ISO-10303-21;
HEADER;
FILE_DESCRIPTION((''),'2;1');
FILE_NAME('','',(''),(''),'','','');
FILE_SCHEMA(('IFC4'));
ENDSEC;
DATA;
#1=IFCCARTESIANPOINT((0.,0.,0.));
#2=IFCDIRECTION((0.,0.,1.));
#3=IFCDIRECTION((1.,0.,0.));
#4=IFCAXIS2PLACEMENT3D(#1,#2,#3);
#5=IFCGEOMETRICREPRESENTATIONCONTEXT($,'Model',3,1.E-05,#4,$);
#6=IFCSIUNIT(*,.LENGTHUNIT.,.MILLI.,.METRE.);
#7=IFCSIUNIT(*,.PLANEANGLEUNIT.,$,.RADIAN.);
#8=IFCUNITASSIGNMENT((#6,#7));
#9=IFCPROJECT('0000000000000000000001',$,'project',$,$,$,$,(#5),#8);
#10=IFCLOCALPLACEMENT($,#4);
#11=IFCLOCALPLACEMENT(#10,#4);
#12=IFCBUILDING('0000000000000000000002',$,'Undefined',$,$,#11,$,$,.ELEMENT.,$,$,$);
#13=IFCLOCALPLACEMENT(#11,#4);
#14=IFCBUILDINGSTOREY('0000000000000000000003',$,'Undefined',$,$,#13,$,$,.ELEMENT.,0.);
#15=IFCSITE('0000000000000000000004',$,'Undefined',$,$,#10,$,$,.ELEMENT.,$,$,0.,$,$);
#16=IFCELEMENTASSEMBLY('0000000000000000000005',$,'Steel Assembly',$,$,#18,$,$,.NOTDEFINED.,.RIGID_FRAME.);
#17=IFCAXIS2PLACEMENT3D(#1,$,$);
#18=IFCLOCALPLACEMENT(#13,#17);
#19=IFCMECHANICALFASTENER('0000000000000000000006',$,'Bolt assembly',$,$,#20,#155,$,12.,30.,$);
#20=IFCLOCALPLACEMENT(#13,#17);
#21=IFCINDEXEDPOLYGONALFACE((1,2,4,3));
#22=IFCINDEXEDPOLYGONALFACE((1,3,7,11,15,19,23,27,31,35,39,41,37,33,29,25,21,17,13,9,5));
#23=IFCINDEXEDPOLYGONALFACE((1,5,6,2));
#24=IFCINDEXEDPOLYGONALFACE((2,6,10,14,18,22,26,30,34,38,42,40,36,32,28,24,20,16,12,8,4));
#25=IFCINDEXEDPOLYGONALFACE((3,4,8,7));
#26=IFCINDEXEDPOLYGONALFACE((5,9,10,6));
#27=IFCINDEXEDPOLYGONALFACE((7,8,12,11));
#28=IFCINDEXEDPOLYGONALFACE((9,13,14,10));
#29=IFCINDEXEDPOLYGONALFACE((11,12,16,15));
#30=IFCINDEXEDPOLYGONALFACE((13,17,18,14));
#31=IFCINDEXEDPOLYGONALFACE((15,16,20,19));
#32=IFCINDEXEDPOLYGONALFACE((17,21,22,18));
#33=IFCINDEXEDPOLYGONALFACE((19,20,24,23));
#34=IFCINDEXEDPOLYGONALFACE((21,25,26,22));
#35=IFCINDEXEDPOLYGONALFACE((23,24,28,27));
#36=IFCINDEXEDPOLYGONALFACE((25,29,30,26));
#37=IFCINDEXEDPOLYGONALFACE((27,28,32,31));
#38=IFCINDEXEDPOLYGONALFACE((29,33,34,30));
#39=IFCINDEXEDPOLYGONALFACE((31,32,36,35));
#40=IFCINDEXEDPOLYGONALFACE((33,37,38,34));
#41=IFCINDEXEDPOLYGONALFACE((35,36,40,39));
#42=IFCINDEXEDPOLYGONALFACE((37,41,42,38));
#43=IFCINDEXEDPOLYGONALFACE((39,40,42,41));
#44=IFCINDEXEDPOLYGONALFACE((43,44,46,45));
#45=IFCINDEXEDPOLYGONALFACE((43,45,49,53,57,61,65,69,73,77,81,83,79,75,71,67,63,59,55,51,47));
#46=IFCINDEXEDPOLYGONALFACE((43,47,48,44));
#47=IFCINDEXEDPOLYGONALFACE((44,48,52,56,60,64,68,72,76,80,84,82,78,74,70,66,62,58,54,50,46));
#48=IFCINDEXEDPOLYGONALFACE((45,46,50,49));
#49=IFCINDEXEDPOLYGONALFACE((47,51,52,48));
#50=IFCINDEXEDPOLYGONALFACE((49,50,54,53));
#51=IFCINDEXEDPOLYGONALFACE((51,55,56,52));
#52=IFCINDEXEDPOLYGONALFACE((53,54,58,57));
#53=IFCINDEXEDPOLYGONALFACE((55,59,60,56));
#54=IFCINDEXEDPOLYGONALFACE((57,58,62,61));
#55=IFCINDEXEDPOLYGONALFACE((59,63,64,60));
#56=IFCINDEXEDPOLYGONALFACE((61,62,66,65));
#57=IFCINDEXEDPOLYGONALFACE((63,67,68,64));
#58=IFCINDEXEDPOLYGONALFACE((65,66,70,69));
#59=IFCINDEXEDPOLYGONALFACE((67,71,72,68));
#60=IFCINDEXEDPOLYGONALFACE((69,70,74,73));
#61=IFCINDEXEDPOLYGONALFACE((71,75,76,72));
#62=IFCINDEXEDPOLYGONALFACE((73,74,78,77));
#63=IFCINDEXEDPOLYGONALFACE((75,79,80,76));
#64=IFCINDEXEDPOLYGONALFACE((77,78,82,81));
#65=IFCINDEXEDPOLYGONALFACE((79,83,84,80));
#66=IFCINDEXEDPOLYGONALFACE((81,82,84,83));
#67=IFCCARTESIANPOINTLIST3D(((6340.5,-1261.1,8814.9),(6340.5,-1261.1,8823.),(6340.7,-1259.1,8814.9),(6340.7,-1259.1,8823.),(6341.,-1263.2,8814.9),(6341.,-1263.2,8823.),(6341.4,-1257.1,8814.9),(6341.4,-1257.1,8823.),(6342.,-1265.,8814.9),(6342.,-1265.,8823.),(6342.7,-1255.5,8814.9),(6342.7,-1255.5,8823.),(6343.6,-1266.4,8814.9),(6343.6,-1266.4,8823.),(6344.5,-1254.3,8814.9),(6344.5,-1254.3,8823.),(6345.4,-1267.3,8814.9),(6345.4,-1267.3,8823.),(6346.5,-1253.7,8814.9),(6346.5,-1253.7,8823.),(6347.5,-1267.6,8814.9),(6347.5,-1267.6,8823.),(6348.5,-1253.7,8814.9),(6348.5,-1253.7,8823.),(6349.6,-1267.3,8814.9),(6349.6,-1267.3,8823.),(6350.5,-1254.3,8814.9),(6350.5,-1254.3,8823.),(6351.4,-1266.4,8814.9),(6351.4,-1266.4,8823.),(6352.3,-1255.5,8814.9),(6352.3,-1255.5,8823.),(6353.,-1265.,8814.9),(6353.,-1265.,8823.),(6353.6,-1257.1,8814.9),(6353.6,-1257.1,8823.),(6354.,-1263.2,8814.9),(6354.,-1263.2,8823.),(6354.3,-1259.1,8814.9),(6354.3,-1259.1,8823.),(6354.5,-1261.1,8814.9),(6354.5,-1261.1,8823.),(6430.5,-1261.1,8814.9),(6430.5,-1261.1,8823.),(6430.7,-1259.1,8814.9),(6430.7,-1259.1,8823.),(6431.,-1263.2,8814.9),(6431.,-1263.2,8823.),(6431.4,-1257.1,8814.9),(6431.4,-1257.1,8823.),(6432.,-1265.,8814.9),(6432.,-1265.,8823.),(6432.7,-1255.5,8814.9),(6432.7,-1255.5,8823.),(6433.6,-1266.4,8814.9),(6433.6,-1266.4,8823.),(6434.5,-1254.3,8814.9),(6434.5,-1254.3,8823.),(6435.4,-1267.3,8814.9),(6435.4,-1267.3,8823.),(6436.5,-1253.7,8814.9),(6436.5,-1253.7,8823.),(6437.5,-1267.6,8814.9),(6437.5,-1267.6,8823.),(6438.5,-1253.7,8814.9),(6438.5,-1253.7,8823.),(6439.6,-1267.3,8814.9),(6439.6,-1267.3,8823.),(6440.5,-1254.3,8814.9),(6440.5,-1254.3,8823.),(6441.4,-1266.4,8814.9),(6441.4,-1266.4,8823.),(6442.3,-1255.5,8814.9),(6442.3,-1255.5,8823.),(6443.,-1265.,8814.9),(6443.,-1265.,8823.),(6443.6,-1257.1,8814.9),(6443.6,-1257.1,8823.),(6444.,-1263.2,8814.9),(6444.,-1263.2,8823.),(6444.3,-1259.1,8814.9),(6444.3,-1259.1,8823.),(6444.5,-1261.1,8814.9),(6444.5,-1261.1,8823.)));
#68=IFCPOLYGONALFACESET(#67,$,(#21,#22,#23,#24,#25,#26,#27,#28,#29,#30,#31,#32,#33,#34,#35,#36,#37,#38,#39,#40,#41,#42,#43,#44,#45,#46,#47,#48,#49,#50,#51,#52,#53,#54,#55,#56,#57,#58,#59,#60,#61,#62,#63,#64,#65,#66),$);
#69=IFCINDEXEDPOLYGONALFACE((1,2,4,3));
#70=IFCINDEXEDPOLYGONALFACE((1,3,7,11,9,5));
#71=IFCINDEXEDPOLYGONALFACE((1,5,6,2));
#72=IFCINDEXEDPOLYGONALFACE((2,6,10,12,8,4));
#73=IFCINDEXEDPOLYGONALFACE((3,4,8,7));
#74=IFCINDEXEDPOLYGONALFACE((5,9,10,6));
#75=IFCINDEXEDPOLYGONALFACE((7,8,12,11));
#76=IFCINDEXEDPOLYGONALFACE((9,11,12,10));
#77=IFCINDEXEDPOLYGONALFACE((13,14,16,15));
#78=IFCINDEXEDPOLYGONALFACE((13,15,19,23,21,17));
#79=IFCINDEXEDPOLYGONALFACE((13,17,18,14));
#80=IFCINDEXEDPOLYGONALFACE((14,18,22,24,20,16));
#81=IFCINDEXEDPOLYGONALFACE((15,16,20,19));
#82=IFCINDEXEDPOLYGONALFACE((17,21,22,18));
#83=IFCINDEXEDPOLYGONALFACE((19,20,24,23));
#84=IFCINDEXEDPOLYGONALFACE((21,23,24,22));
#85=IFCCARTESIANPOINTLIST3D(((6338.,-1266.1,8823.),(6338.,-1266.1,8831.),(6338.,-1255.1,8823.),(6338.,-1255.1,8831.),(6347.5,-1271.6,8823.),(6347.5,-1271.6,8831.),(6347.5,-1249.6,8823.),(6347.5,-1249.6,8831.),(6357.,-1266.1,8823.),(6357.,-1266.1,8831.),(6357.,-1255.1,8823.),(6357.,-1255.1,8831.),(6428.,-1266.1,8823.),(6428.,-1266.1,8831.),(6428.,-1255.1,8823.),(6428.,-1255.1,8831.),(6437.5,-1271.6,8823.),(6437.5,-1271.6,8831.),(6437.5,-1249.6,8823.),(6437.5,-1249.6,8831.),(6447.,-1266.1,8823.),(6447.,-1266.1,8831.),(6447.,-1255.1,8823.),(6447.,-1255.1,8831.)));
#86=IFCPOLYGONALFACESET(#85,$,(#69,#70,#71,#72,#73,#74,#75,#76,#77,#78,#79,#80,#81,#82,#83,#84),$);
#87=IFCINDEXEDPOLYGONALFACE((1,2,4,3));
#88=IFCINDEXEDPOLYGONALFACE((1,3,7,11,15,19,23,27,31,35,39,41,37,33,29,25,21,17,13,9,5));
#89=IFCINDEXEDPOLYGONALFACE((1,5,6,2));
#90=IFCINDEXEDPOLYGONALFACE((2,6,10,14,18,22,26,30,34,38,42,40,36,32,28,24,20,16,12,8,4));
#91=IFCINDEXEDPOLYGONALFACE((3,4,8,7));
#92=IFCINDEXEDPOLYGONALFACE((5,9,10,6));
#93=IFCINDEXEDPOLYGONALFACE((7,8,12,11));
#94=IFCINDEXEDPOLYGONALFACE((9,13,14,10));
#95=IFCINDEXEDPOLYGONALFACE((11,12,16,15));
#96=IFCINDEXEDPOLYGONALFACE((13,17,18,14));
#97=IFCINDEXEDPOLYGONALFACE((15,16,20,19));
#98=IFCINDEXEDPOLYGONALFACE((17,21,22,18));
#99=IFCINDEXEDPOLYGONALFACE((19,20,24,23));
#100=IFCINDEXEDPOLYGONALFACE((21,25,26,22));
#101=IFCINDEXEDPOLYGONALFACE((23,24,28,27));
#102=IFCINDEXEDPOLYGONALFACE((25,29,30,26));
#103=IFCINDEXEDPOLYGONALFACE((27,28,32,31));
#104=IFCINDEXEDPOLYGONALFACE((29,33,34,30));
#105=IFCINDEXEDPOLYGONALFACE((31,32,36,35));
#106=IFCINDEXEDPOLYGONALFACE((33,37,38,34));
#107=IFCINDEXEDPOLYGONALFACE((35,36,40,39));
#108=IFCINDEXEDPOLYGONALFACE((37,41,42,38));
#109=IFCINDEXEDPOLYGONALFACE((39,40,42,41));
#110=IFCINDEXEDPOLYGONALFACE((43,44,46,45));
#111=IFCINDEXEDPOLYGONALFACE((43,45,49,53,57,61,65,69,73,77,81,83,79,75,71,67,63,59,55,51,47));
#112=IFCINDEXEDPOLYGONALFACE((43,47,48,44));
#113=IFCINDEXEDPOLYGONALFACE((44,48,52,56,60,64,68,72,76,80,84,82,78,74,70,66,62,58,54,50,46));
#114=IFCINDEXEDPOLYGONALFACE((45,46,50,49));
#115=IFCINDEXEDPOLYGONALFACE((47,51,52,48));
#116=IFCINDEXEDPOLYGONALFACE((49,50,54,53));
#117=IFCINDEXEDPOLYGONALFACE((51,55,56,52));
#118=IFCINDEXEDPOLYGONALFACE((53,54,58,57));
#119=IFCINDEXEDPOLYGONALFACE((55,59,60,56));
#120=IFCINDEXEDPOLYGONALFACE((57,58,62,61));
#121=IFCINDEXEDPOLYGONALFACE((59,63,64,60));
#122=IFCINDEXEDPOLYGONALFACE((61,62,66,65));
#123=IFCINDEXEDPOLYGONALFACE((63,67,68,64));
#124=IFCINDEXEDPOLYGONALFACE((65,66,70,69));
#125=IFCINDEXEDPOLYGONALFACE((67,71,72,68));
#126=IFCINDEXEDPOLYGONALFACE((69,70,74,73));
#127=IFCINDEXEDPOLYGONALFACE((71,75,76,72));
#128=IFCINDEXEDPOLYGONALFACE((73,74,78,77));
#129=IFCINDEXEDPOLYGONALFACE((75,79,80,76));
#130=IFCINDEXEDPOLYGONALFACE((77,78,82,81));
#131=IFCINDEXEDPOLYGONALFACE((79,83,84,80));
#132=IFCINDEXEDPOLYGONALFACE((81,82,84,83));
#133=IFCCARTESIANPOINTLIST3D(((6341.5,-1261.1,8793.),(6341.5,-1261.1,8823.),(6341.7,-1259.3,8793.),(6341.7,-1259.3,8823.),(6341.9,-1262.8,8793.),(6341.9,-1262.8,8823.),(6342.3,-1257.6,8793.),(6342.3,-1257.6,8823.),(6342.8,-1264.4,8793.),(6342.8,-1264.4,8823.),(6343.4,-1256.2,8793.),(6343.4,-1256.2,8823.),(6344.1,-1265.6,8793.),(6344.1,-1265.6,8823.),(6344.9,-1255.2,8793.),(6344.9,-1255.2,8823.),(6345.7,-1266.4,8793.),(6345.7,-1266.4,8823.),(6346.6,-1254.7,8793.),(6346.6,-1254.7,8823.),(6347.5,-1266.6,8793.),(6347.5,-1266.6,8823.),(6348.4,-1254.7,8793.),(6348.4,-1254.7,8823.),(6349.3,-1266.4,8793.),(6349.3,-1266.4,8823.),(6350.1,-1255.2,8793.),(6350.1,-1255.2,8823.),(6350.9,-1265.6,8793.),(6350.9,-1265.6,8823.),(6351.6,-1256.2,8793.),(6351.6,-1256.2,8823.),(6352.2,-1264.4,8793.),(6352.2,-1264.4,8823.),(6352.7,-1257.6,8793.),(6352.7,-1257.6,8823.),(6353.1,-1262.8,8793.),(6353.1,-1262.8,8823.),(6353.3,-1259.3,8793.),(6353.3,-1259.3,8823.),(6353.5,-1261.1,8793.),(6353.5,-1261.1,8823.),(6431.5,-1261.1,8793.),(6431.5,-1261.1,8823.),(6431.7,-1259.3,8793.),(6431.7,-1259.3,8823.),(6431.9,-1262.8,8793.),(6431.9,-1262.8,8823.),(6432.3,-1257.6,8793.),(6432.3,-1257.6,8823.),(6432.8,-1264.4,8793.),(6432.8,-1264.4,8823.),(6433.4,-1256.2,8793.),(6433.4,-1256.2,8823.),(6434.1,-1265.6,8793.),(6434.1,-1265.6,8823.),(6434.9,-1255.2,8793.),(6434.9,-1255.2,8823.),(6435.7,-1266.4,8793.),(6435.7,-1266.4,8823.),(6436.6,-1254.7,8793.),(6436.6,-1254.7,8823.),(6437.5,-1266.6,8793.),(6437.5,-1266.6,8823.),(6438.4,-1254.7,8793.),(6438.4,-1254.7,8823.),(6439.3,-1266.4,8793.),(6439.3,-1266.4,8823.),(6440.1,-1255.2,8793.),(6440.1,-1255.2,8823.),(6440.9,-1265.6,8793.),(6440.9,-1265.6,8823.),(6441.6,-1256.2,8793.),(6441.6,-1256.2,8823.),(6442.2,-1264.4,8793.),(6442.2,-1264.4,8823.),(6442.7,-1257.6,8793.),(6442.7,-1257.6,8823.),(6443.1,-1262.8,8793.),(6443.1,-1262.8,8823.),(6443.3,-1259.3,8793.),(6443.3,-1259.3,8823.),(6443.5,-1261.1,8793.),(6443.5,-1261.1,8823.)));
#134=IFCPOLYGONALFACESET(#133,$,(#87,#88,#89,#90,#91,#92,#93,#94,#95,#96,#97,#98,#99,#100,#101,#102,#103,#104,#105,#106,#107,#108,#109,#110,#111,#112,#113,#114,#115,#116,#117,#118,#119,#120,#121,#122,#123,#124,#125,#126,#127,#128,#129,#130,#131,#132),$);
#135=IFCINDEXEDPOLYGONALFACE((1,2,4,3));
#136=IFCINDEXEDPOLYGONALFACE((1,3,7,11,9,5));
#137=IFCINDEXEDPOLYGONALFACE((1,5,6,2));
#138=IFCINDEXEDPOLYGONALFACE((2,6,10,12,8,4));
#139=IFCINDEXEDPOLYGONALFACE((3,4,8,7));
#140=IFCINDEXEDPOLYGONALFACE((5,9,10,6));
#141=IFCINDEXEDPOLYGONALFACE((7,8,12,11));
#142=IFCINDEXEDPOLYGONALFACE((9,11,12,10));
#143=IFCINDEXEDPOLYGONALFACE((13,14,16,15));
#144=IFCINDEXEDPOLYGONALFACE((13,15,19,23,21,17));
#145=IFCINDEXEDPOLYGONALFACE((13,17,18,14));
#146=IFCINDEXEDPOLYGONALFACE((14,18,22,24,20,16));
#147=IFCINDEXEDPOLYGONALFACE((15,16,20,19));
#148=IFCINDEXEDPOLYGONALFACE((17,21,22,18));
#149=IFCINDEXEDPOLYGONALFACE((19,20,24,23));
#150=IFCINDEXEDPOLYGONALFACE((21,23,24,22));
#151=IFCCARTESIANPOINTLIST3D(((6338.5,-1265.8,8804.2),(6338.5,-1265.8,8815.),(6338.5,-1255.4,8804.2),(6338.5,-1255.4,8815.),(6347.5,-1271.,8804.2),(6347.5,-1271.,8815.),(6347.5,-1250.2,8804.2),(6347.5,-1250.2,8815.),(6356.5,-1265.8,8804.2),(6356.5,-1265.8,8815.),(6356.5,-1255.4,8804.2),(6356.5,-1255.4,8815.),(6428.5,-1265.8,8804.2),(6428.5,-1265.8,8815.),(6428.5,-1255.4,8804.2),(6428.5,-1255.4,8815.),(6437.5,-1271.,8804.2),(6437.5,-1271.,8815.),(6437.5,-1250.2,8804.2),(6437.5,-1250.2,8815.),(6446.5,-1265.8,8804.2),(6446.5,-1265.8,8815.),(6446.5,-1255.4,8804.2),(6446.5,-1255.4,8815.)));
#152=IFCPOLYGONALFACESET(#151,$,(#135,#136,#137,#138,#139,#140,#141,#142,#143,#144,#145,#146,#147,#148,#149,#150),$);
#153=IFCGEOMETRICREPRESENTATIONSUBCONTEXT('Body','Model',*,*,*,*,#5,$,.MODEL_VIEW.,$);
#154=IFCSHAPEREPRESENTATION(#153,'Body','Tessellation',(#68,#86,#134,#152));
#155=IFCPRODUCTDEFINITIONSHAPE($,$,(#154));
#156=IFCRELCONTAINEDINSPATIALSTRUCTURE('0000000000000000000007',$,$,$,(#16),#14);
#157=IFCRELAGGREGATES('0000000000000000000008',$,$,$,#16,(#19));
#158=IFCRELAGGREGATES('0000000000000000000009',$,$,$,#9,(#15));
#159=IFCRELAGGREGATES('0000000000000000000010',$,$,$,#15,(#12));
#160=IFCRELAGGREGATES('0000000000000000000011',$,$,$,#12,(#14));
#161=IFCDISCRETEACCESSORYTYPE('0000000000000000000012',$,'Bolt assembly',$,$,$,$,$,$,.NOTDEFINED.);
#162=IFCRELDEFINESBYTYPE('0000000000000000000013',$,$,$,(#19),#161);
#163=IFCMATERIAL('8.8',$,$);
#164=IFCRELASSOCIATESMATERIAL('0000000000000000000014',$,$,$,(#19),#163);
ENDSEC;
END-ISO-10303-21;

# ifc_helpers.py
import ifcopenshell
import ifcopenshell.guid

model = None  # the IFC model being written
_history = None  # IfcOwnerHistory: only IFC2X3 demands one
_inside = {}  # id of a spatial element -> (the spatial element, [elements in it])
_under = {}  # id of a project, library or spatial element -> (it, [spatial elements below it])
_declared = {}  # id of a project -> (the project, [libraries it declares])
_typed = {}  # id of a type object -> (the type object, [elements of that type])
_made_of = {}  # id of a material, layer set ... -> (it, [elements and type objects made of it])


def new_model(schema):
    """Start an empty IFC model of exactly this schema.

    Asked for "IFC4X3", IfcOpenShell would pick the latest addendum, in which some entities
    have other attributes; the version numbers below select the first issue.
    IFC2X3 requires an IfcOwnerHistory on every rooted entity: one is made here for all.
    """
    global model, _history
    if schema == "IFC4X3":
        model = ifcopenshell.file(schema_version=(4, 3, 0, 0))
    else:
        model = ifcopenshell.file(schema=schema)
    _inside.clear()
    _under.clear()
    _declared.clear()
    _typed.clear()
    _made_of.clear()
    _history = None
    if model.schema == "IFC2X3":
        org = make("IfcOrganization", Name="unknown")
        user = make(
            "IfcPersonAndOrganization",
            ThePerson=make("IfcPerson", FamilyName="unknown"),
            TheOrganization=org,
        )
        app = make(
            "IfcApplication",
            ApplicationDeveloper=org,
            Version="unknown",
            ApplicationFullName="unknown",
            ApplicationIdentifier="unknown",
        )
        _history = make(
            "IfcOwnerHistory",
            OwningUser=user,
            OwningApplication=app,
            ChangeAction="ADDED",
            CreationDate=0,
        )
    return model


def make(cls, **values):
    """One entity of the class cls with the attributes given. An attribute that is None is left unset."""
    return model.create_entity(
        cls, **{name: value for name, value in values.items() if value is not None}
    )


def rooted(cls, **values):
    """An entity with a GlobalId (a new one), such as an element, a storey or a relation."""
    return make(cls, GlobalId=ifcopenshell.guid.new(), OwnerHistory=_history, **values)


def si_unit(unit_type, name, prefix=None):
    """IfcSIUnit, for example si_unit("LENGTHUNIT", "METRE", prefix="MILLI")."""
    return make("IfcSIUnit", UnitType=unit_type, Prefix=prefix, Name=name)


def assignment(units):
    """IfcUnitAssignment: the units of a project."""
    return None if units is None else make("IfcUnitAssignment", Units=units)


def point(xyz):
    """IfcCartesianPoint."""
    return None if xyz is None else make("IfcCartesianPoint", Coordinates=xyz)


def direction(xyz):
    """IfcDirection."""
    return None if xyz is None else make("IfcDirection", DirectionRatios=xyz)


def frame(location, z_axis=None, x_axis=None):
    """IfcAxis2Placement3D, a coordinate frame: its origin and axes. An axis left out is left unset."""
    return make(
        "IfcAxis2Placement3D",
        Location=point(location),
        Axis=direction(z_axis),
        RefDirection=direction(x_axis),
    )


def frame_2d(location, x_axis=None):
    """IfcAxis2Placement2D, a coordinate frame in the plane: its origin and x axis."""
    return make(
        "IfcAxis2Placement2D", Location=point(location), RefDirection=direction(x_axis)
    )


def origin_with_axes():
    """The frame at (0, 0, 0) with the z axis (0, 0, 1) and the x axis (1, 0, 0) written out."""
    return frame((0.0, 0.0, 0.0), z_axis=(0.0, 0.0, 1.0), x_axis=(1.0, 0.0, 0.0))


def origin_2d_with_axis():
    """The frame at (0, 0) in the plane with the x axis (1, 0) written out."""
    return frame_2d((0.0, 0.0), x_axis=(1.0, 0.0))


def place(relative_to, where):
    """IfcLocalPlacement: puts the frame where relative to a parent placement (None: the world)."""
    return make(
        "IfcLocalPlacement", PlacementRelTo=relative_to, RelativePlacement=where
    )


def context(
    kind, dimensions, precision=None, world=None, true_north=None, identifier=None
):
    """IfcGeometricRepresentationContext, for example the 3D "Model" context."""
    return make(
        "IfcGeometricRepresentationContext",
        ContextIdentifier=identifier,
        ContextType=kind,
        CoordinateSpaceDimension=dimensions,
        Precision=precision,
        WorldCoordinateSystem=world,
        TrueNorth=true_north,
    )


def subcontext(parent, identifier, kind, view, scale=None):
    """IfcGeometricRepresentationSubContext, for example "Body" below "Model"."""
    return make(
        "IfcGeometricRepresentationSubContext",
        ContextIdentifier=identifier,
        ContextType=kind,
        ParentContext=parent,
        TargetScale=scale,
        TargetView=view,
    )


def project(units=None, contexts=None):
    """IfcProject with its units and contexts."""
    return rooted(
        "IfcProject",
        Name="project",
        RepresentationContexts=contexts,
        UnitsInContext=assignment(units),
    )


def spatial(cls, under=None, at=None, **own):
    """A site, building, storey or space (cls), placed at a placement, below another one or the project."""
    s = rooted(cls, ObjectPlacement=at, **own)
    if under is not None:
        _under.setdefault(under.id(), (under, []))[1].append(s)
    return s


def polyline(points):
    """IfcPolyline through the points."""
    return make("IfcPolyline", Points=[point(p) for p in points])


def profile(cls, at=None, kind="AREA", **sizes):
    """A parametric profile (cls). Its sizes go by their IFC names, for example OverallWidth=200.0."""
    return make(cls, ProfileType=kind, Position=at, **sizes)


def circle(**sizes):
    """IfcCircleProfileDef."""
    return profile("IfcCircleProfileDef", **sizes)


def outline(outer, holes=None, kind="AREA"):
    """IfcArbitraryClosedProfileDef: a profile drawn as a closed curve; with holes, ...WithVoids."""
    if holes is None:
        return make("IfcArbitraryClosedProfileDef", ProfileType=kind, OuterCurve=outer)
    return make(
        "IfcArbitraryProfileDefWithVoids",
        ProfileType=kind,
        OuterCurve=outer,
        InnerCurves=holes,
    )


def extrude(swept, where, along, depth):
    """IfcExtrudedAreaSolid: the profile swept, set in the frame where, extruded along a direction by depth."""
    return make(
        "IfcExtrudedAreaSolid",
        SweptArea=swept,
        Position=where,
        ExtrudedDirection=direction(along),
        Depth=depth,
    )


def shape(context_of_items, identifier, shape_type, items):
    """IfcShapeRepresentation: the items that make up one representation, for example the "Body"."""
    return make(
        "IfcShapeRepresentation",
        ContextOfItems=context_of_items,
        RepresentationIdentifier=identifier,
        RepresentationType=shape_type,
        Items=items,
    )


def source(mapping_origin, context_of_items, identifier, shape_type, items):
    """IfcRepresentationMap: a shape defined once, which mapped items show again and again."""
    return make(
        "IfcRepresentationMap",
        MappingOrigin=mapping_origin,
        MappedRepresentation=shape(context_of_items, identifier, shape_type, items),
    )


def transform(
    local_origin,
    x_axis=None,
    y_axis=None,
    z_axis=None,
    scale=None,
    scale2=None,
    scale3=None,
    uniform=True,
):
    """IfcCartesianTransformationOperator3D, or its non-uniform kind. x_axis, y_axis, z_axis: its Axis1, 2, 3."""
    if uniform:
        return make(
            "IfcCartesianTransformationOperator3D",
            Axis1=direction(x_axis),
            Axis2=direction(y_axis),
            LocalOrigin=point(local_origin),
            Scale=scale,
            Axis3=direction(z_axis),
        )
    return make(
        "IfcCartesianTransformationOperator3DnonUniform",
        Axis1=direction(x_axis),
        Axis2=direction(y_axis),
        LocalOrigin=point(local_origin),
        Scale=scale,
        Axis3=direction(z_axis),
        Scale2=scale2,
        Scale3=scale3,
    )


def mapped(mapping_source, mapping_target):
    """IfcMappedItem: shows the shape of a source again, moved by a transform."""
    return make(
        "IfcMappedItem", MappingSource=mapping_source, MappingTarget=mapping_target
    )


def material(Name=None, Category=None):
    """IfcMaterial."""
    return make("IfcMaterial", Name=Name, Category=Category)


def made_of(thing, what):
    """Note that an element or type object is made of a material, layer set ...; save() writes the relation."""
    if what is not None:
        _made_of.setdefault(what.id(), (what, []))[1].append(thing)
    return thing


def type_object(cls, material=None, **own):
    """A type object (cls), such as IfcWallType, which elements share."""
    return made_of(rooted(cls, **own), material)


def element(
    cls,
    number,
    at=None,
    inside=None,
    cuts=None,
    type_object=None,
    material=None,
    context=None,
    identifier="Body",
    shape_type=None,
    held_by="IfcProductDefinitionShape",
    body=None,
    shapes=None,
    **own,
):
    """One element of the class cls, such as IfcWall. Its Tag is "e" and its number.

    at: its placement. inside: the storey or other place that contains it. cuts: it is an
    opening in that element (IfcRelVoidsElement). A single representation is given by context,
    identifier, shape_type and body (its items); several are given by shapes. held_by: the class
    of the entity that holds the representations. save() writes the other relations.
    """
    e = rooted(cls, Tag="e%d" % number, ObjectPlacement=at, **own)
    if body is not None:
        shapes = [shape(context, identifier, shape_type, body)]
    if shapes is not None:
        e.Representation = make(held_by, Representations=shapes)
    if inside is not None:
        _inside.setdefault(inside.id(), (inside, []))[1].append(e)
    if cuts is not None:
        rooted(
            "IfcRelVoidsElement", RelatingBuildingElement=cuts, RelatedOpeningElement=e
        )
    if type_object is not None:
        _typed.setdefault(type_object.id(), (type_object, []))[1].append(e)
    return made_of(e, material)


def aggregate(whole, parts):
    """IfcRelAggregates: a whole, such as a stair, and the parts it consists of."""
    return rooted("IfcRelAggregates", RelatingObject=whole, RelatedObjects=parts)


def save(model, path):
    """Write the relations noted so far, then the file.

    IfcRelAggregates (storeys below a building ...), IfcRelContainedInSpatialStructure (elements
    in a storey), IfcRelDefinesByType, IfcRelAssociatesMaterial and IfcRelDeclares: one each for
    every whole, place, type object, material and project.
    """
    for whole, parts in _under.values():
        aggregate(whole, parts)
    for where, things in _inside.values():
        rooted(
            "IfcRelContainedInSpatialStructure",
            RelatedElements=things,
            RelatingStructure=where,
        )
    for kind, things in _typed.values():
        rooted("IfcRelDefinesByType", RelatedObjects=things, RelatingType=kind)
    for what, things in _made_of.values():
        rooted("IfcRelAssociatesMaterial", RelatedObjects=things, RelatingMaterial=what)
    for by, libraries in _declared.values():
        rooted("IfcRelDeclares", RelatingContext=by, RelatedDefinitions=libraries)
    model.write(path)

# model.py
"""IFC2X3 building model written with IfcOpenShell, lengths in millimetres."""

from ifc_helpers import new_model, si_unit, frame, origin_with_axes, origin_2d_with_axis, place, context, subcontext, project, spatial, polyline, circle, outline, extrude, source, transform, mapped, material, type_object, element, aggregate, save


model = new_model("IFC2X3")

# Units and contexts
model_context = context("Model", 3, precision=1e-05, world=origin_with_axes())
body_context = subcontext(model_context, "Body", "Model", "MODEL_VIEW")
ifc_project = project(units=[si_unit("LENGTHUNIT", "METRE", prefix="MILLI"), si_unit("PLANEANGLEUNIT", "RADIAN")], contexts=[model_context])

# Site, building, storey
site_placement = place(None, origin_with_axes())
site = spatial("IfcSite", under=ifc_project, at=site_placement, Name="Undefined", CompositionType="ELEMENT", RefElevation=0.0)
building_placement = place(site_placement, origin_with_axes())
building = spatial("IfcBuilding", under=site, at=building_placement, Name="Undefined", CompositionType="ELEMENT")
storey_placement = place(building_placement, origin_with_axes())
storey = spatial("IfcBuildingStorey", under=building, at=storey_placement, Name="Undefined", CompositionType="ELEMENT", Elevation=0.0)

# Element assembly
assembly_1_placement = place(storey_placement, origin_with_axes())
assembly_1 = element("IfcElementAssembly", 1, at=assembly_1_placement, inside=storey, Name="Steel Assembly", AssemblyPlace="NOTDEFINED", PredefinedType="RIGID_FRAME")

# Mechanical fastener
ifc_material_1 = material(Name="8.8")
discrete_accessory_type_1 = type_object("IfcDiscreteAccessoryType", Name="Bolt assembly")
shared_shape_1 = source(origin_with_axes(), body_context, "Body", "SweptSolid", [
    extrude(circle(Radius=7.0, at=origin_2d_with_axis()), frame((0.0, 0.0, 0.0), z_axis=(0.0, 1.0, 0.0), x_axis=(1.0, 0.0, 0.0)), (0.0, 0.0, 1.0), 8.1),
    extrude(outline(polyline([(11.0, 0.0), (5.5, 9.5), (-5.5, 9.5), (-11.0, 0.0), (-5.5, -9.5), (5.5, -9.5), (11.0, 0.0)])), frame((0.0, -8.0, 0.0), z_axis=(0.0, 1.0, 0.0), x_axis=(1.0, 0.0, 0.0)), (0.0, 0.0, 1.0), 8.0),
    extrude(circle(Radius=6.0, at=origin_2d_with_axis()), frame((0.0, 0.0, 0.0), z_axis=(0.0, 1.0, 0.0), x_axis=(1.0, 0.0, 0.0)), (0.0, 0.0, 1.0), 30.0),
    extrude(outline(polyline([(10.4, 0.0), (5.2, 9.0), (-5.2, 9.0), (-10.4, 0.0), (-5.2, -9.0), (5.2, -9.0), (10.4, 0.0)])), frame((0.0, 8.0, 0.0), z_axis=(0.0, 1.0, 0.0), x_axis=(1.0, 0.0, 0.0)), (0.0, 0.0, 1.0), 10.8),
])
mechanical_fastener_1_placement = place(assembly_1_placement, frame((6392.5, -1240.6, 8823.0), z_axis=(1.0, 0.0, 0.0), x_axis=(0.0, -1.0, 0.0)))
mechanical_fastener_1 = element("IfcMechanicalFastener", 2, at=mechanical_fastener_1_placement, type_object=discrete_accessory_type_1, material=ifc_material_1, Name="Bolt assembly", NominalDiameter=12.0, NominalLength=30.0, context=body_context, shape_type="MappedRepresentation", body=[
    mapped(shared_shape_1, transform((20.0, 0.0, -45.0))),
    mapped(shared_shape_1, transform((20.0, 0.0, 45.0))),
])

aggregate(assembly_1, [mechanical_fastener_1])

save(model, "model.ifc")
